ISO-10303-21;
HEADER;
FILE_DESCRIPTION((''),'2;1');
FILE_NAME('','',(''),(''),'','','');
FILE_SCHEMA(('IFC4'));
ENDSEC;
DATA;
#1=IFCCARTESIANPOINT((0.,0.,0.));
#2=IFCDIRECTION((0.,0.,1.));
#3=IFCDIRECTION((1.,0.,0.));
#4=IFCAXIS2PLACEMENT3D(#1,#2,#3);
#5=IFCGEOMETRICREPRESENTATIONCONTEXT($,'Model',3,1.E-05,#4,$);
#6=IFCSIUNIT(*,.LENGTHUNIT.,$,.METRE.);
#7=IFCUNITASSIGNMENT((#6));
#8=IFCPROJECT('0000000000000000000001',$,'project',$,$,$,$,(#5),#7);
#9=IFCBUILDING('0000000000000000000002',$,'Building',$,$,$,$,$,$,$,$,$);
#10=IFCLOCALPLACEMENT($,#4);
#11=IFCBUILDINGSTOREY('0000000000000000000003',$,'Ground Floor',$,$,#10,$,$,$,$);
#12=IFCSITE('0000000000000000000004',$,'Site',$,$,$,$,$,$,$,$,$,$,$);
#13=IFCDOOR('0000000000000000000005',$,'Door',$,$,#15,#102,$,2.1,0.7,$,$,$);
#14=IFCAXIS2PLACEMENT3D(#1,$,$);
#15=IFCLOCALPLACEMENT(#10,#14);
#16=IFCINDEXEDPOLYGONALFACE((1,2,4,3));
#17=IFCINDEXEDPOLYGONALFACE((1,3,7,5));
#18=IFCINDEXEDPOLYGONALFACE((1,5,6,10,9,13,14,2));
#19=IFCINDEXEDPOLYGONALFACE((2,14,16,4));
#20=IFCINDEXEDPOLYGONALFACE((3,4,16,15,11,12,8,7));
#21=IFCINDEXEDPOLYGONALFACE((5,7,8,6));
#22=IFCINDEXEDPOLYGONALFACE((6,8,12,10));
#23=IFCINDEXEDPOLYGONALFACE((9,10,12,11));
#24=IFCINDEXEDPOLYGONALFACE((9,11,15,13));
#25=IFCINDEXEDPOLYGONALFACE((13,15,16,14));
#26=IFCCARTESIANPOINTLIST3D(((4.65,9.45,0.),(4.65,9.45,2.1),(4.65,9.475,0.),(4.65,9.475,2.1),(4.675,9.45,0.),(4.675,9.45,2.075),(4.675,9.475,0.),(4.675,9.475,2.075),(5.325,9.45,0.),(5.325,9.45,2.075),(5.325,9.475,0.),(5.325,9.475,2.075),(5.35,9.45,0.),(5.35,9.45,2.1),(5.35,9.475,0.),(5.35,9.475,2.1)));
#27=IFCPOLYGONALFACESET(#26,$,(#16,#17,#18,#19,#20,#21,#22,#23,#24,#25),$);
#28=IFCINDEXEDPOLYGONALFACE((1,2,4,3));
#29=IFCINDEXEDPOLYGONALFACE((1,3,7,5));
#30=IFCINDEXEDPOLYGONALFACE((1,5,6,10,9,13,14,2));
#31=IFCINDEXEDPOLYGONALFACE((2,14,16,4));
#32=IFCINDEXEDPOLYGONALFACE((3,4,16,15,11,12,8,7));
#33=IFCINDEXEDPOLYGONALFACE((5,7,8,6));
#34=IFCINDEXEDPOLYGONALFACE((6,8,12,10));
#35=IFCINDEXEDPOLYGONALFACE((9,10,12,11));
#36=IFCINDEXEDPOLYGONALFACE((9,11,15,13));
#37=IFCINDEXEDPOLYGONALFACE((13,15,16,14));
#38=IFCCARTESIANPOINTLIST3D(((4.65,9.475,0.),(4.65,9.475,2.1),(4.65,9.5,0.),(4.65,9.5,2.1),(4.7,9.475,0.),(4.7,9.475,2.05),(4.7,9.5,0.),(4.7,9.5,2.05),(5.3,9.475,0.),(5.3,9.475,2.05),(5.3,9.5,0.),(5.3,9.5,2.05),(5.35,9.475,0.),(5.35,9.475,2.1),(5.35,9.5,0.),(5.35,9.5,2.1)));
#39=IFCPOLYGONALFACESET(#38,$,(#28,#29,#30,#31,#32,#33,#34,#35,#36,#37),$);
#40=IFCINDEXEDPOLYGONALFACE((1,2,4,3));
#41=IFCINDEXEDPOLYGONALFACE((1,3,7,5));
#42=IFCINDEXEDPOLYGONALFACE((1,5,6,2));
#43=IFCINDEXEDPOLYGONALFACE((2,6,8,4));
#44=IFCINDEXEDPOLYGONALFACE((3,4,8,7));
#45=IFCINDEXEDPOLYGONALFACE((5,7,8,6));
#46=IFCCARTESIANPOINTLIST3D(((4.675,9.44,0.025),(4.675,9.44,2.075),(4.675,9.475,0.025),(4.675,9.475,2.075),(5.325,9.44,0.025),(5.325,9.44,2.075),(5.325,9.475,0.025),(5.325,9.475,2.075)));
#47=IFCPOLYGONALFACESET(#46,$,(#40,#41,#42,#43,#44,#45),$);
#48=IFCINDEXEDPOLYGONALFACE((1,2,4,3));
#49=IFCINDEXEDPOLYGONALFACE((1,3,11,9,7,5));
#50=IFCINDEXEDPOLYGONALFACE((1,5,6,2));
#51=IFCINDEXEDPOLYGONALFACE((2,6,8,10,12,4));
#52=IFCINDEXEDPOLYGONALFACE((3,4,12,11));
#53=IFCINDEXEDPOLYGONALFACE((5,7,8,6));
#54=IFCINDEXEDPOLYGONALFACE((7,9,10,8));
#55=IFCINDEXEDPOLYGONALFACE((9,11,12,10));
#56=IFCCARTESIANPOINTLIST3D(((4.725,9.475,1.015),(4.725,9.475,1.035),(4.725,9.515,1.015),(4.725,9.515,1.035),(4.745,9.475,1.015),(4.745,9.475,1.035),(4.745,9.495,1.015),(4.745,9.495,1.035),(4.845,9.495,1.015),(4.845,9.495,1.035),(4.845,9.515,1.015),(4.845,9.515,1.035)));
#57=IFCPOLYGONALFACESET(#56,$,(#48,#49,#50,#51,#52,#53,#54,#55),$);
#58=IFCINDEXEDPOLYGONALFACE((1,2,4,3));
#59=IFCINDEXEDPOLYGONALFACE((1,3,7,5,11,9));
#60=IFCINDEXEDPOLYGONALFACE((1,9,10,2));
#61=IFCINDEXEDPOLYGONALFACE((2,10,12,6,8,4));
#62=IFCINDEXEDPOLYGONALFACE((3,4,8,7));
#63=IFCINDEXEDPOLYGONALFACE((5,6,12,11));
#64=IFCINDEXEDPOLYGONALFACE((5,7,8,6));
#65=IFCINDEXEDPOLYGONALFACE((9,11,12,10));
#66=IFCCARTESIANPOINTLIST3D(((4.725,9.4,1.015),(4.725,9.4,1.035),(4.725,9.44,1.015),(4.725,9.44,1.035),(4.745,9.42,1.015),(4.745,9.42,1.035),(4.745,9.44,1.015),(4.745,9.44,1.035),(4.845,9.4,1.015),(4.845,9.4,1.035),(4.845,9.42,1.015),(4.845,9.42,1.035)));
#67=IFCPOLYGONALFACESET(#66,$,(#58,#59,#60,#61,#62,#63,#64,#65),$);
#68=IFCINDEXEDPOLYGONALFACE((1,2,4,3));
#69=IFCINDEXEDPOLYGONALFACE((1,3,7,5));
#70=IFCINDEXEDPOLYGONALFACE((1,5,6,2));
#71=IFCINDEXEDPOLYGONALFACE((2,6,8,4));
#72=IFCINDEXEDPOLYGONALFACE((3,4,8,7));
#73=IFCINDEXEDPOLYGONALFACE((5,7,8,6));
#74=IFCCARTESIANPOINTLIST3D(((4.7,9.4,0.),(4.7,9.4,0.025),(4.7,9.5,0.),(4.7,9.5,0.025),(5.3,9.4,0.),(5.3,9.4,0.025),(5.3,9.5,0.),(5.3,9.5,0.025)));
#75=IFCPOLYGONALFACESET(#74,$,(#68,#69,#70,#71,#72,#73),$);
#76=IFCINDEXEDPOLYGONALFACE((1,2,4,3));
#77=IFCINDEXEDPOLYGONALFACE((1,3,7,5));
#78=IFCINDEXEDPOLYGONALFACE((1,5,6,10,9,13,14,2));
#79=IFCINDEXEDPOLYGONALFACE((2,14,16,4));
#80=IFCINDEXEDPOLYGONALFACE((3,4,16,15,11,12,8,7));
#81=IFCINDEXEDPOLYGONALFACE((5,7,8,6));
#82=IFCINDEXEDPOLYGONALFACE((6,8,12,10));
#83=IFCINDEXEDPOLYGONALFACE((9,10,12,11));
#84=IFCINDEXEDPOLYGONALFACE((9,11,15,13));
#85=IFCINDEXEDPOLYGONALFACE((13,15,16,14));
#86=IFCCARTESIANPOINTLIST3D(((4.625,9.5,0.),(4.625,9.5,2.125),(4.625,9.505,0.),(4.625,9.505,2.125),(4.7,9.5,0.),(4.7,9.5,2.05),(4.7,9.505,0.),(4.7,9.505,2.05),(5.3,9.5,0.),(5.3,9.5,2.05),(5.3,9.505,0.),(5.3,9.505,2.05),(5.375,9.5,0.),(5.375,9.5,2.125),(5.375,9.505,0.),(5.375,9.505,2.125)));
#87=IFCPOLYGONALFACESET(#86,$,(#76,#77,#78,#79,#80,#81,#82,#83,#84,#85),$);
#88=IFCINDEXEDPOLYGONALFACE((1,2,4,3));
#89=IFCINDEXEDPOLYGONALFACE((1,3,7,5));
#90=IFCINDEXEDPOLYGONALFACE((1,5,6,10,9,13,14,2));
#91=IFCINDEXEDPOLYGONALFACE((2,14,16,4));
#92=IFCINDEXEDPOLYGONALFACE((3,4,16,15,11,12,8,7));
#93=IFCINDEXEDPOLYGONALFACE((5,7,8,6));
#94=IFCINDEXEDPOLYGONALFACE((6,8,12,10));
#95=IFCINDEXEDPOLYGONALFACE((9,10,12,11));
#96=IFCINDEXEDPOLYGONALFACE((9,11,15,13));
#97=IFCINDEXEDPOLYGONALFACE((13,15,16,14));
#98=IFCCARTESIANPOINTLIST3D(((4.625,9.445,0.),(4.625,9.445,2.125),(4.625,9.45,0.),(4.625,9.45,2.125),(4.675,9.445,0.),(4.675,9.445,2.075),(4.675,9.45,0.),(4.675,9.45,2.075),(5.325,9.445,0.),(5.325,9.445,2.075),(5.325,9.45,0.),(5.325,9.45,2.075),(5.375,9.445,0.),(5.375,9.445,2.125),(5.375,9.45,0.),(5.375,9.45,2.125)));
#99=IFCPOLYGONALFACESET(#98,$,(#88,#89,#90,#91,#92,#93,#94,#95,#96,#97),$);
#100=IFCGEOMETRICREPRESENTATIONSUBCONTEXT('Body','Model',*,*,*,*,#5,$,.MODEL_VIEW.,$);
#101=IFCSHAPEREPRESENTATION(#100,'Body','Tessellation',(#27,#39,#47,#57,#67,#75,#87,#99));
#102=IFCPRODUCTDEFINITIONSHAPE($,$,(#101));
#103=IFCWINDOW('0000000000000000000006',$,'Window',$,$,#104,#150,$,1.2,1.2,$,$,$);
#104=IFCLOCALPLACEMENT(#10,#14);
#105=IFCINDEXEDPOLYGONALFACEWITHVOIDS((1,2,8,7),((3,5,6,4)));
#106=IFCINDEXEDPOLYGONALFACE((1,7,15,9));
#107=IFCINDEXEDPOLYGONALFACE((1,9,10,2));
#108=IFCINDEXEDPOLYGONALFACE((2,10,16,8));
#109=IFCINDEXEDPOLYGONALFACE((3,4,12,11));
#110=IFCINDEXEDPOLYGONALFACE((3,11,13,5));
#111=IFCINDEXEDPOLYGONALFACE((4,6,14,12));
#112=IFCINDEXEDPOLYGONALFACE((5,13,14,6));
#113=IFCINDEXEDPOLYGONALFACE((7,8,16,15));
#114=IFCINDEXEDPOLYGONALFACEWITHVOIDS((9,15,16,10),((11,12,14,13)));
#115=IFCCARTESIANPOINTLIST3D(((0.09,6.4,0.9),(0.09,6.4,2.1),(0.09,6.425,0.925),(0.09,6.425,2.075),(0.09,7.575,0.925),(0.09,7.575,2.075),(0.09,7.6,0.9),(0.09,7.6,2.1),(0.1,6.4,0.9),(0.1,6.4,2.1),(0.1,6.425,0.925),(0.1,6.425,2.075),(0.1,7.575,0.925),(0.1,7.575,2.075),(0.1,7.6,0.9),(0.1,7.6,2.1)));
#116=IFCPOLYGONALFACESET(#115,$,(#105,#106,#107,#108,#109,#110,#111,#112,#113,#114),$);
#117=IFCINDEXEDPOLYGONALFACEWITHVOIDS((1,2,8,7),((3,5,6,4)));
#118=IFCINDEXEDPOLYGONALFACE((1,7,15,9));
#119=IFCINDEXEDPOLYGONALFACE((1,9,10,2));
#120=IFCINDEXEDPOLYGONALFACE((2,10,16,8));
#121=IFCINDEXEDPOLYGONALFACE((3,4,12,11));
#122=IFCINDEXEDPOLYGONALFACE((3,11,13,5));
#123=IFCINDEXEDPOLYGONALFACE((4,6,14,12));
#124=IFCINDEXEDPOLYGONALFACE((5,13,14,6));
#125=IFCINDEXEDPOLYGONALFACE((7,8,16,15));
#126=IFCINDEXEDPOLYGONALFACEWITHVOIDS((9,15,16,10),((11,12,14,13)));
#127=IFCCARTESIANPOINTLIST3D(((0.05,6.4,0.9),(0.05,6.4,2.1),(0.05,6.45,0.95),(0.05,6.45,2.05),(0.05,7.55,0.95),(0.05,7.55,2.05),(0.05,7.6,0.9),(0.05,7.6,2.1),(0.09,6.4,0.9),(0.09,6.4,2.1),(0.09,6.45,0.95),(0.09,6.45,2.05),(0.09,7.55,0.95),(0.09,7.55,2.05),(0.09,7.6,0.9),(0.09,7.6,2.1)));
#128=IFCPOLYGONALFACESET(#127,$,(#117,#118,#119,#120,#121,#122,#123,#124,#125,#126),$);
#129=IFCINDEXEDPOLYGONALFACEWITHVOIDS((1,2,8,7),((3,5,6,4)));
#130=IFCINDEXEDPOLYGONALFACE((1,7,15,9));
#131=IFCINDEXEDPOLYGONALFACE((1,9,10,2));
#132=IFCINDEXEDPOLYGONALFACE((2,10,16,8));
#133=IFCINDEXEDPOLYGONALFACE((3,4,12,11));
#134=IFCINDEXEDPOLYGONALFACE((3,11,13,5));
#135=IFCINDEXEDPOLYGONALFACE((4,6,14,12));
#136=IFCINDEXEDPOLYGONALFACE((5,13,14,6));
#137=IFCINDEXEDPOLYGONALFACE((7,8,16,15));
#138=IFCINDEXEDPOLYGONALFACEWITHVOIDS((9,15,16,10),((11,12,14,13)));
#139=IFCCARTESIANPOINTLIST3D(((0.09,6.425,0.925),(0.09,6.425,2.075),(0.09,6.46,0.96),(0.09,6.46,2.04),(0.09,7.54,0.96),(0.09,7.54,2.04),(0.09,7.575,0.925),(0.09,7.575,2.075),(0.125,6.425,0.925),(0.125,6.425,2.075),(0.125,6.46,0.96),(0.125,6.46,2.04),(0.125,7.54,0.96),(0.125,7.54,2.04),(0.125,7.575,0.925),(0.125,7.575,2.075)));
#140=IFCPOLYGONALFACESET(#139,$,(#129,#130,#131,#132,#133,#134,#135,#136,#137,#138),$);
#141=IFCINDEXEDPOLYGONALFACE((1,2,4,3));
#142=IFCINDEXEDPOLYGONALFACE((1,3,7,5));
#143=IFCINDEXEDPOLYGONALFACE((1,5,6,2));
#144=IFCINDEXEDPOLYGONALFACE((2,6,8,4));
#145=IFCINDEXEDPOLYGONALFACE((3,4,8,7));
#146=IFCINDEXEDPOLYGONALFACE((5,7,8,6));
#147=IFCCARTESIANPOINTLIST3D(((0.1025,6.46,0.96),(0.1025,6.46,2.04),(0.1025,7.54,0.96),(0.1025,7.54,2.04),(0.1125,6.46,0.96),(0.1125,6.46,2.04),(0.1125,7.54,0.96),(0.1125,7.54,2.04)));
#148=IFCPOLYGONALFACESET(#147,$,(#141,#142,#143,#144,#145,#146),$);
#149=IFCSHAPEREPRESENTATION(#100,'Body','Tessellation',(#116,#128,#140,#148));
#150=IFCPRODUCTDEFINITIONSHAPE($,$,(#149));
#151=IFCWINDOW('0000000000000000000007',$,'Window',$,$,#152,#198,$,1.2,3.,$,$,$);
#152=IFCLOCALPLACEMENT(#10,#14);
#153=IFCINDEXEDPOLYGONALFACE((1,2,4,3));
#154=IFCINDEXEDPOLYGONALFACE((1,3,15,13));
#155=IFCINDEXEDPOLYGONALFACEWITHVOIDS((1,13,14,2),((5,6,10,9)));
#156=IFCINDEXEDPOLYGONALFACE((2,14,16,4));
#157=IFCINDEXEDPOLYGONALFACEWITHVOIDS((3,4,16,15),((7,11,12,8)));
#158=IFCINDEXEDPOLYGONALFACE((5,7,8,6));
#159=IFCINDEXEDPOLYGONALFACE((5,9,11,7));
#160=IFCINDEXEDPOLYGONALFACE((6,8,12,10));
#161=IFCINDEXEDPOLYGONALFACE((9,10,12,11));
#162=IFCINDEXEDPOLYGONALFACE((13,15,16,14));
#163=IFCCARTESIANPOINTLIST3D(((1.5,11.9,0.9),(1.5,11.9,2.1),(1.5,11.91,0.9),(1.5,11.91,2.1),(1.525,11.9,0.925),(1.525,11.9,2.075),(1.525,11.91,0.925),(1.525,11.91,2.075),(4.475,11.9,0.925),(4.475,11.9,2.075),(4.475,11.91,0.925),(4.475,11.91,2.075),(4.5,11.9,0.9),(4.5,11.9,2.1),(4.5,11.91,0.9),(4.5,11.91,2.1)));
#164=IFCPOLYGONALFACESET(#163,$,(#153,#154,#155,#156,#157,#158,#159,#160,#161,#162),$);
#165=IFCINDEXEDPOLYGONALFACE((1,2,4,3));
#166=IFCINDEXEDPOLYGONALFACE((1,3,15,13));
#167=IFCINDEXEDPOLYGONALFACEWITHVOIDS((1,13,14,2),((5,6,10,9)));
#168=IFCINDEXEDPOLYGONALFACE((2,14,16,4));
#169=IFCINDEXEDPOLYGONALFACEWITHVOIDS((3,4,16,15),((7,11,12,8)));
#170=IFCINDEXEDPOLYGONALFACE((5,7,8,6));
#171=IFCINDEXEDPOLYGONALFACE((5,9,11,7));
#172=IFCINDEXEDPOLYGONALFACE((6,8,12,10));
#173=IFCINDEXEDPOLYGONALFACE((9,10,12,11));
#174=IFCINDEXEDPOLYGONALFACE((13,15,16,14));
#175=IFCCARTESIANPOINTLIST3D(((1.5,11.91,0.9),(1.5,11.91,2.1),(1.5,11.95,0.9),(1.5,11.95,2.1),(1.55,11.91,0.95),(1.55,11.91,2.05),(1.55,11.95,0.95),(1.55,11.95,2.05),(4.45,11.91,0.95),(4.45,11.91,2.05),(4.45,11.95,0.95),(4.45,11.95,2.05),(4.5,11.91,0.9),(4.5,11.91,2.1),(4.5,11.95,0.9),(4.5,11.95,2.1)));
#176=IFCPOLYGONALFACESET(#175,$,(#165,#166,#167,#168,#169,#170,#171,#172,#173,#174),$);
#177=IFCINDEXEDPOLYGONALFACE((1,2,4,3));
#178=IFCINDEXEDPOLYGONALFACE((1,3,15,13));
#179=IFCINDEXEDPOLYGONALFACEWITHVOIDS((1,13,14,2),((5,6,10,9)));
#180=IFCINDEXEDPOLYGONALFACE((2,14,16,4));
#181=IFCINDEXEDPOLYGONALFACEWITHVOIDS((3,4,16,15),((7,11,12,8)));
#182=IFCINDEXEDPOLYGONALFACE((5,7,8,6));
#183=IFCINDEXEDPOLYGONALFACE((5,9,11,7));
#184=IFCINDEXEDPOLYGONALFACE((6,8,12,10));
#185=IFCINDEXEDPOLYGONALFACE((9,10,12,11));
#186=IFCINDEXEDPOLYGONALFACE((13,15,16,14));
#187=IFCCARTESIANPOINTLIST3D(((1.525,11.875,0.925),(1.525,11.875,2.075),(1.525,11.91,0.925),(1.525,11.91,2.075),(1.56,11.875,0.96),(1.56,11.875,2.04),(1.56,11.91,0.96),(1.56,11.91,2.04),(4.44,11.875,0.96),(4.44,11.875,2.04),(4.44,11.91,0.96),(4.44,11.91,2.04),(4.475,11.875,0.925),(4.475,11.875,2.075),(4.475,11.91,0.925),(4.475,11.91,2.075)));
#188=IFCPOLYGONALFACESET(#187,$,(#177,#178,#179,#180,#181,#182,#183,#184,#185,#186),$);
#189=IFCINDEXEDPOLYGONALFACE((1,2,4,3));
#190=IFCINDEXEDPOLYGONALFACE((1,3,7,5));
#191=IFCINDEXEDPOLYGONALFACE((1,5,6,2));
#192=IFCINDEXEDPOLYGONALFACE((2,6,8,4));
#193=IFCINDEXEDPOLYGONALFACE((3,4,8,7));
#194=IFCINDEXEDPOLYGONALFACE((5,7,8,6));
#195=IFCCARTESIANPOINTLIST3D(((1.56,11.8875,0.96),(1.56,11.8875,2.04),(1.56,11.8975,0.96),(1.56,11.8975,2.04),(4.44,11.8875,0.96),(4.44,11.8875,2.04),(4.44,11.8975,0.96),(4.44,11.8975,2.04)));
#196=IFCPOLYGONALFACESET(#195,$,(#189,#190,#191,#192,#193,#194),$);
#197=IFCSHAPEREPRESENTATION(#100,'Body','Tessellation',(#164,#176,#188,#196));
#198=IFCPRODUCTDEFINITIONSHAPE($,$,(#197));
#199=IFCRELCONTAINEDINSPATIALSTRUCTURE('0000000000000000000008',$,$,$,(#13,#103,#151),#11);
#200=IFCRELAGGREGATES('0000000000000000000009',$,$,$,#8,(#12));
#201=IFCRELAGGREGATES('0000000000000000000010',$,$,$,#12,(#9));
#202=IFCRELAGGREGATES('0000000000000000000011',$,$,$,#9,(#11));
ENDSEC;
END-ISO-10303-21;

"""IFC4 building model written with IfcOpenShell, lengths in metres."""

from ifc_helpers import new_model, si_unit, frame, origin_with_axes, place, context, subcontext, project, spatial, line, indexed_curve, outline, extrude, element, save


model = new_model("IFC4")

# Units and contexts
model_context = context("Model", 3, precision=1e-05, world=origin_with_axes())
body_context = subcontext(model_context, "Body", "Model", "MODEL_VIEW")
ifc_project = project(units=[si_unit("LENGTHUNIT", "METRE")], contexts=[model_context])

# Site, building, storey
site = spatial("IfcSite", under=ifc_project, Name="Site")
building = spatial("IfcBuilding", under=site, Name="Building")
storey_placement = place(None, origin_with_axes())
storey = spatial("IfcBuildingStorey", under=building, at=storey_placement, Name="Ground Floor")

# Door
door_1_placement = place(storey_placement, frame((5.35, 9.5, 0.0), z_axis=(0.0, 0.0, 1.0), x_axis=(-1.0, 0.0, 0.0)))
element("IfcDoor", 1, at=door_1_placement, inside=storey, Name="Door", OverallHeight=2.1, OverallWidth=0.7, context=body_context, shape_type="SweptSolid", body=[
    extrude(outline(indexed_curve([(0.0, 0.0), (0.0, 2.1), (0.7, 2.1), (0.7, 0.0), (0.675, 0.0), (0.675, 2.075), (0.025, 2.075), (0.025, 0.0)], segments=[line(1, 2, 3, 4, 5, 6, 7, 8, 1)])), frame((0.0, 0.025, 0.0), z_axis=(0.0, -1.0, 0.0), x_axis=(1.0, 0.0, 0.0)), (0.0, 0.0, -1.0), 0.025),
    extrude(outline(indexed_curve([(0.0, 0.0), (0.0, 2.1), (0.7, 2.1), (0.7, 0.0), (0.65, 0.0), (0.65, 2.05), (0.05, 2.05), (0.05, 0.0)], segments=[line(1, 2, 3, 4, 5, 6, 7, 8, 1)])), frame((0.0, 0.0, 0.0), z_axis=(0.0, -1.0, 0.0), x_axis=(1.0, 0.0, 0.0)), (0.0, 0.0, -1.0), 0.025),
    extrude(outline(indexed_curve([(0.0, 0.0), (0.65, 0.0), (0.65, 0.035), (0.0, 0.035)], segments=[line(1, 2, 3, 4, 1)])), frame((0.025, 0.025, 0.025), z_axis=(0.0, 0.0, 1.0), x_axis=(1.0, 0.0, 0.0)), (0.0, 0.0, 1.0), 2.05),
    extrude(outline(indexed_curve([(0.0, 0.0), (0.0, -0.04), (-0.12, -0.04), (-0.12, -0.02), (-0.02, -0.02), (-0.02, 0.0)], segments=[line(1, 2, 3, 4, 5, 6, 1)])), frame((0.625, 0.025, 1.015), z_axis=(0.0, 0.0, 1.0), x_axis=(1.0, 0.0, 0.0)), (0.0, 0.0, 1.0), 0.02),
    extrude(outline(indexed_curve([(0.0, 0.0), (0.0, 0.04), (-0.12, 0.04), (-0.12, 0.02), (-0.02, 0.02), (-0.02, 0.0)], segments=[line(1, 2, 3, 4, 5, 6, 1)])), frame((0.625, 0.06, 1.015), z_axis=(0.0, 0.0, 1.0), x_axis=(1.0, 0.0, 0.0)), (0.0, 0.0, 1.0), 0.02),
    extrude(outline(indexed_curve([(0.0, 0.0), (0.6, 0.0), (0.6, 0.1), (0.0, 0.1)], segments=[line(1, 2, 3, 4, 1)])), frame((0.05, 0.0, 0.0), z_axis=(0.0, 0.0, 1.0), x_axis=(1.0, 0.0, 0.0)), (0.0, 0.0, 1.0), 0.025),
    extrude(outline(indexed_curve([(0.0, 0.0), (0.0, 2.125), (0.75, 2.125), (0.75, 0.0), (0.675, 0.0), (0.675, 2.05), (0.075, 2.05), (0.075, 0.0)], segments=[line(1, 2, 3, 4, 5, 6, 7, 8, 1)])), frame((-0.025, -0.005, 0.0), z_axis=(0.0, -1.0, 0.0), x_axis=(1.0, 0.0, 0.0)), (0.0, 0.0, -1.0), 0.005),
    extrude(outline(indexed_curve([(0.0, 0.0), (0.0, 2.125), (0.75, 2.125), (0.75, 0.0), (0.7, 0.0), (0.7, 2.075), (0.05, 2.075), (0.05, 0.0)], segments=[line(1, 2, 3, 4, 5, 6, 7, 8, 1)])), frame((-0.025, 0.05, 0.0), z_axis=(0.0, -1.0, 0.0), x_axis=(1.0, 0.0, 0.0)), (0.0, 0.0, -1.0), 0.005),
])

# Windows
window_1_placement = place(storey_placement, frame((0.0, 7.6, 0.9), z_axis=(0.0, 0.0, 1.0), x_axis=(0.0, -1.0, 0.0)))
element("IfcWindow", 2, at=window_1_placement, inside=storey, Name="Window", OverallHeight=1.2, OverallWidth=1.2, context=body_context, shape_type="SweptSolid", body=[
    extrude(outline(indexed_curve([(0.0, 0.0), (1.2, 0.0), (1.2, 1.2), (0.0, 1.2)], segments=[line(1, 2, 3, 4, 1)]), holes=[indexed_curve([(0.025, 0.025), (1.175, 0.025), (1.175, 1.175), (0.025, 1.175)], segments=[line(1, 2, 3, 4, 1)])]), frame((0.0, 0.09, 0.0), z_axis=(0.0, -1.0, 0.0), x_axis=(1.0, 0.0, 0.0)), (0.0, 0.0, -1.0), 0.01),
    extrude(outline(indexed_curve([(0.0, 0.0), (1.2, 0.0), (1.2, 1.2), (0.0, 1.2)], segments=[line(1, 2, 3, 4, 1)]), holes=[indexed_curve([(0.05, 0.05), (1.15, 0.05), (1.15, 1.15), (0.05, 1.15)], segments=[line(1, 2, 3, 4, 1)])]), frame((0.0, 0.05, 0.0), z_axis=(0.0, -1.0, 0.0), x_axis=(1.0, 0.0, 0.0)), (0.0, 0.0, -1.0), 0.04),
    extrude(outline(indexed_curve([(0.0, 0.0), (1.15, 0.0), (1.15, 1.15), (0.0, 1.15)], segments=[line(1, 2, 3, 4, 1)]), holes=[indexed_curve([(0.035, 0.035), (1.115, 0.035), (1.115, 1.115), (0.035, 1.115)], segments=[line(1, 2, 3, 4, 1)])]), frame((0.025, 0.09, 0.025), z_axis=(0.0, -1.0, 0.0), x_axis=(1.0, 0.0, 0.0)), (0.0, 0.0, -1.0), 0.035),
    extrude(outline(indexed_curve([(0.035, 0.035), (1.115, 0.035), (1.115, 1.115), (0.035, 1.115)], segments=[line(1, 2, 3, 4, 1)])), frame((0.025, 0.1025, 0.025), z_axis=(0.0, -1.0, 0.0), x_axis=(1.0, 0.0, 0.0)), (0.0, 0.0, -1.0), 0.01),
])
window_2_placement = place(storey_placement, frame((4.5, 12.0, 0.9), z_axis=(0.0, 0.0, 1.0), x_axis=(-1.0, 0.0, 0.0)))
element("IfcWindow", 3, at=window_2_placement, inside=storey, Name="Window", OverallHeight=1.2, OverallWidth=3.0, context=body_context, shape_type="SweptSolid", body=[
    extrude(outline(indexed_curve([(0.0, 0.0), (3.0, 0.0), (3.0, 1.2), (0.0, 1.2)], segments=[line(1, 2, 3, 4, 1)]), holes=[indexed_curve([(0.025, 0.025), (2.975, 0.025), (2.975, 1.175), (0.025, 1.175)], segments=[line(1, 2, 3, 4, 1)])]), frame((0.0, 0.09, 0.0), z_axis=(0.0, -1.0, 0.0), x_axis=(1.0, 0.0, 0.0)), (0.0, 0.0, -1.0), 0.01),
    extrude(outline(indexed_curve([(0.0, 0.0), (3.0, 0.0), (3.0, 1.2), (0.0, 1.2)], segments=[line(1, 2, 3, 4, 1)]), holes=[indexed_curve([(0.05, 0.05), (2.95, 0.05), (2.95, 1.15), (0.05, 1.15)], segments=[line(1, 2, 3, 4, 1)])]), frame((0.0, 0.05, 0.0), z_axis=(0.0, -1.0, 0.0), x_axis=(1.0, 0.0, 0.0)), (0.0, 0.0, -1.0), 0.04),
    extrude(outline(indexed_curve([(0.0, 0.0), (2.95, 0.0), (2.95, 1.15), (0.0, 1.15)], segments=[line(1, 2, 3, 4, 1)]), holes=[indexed_curve([(0.035, 0.035), (2.915, 0.035), (2.915, 1.115), (0.035, 1.115)], segments=[line(1, 2, 3, 4, 1)])]), frame((0.025, 0.09, 0.025), z_axis=(0.0, -1.0, 0.0), x_axis=(1.0, 0.0, 0.0)), (0.0, 0.0, -1.0), 0.035),
    extrude(outline(indexed_curve([(0.035, 0.035), (2.915, 0.035), (2.915, 1.115), (0.035, 1.115)], segments=[line(1, 2, 3, 4, 1)])), frame((0.025, 0.1025, 0.025), z_axis=(0.0, -1.0, 0.0), x_axis=(1.0, 0.0, 0.0)), (0.0, 0.0, -1.0), 0.01),
])

save(model, "model.ifc")
